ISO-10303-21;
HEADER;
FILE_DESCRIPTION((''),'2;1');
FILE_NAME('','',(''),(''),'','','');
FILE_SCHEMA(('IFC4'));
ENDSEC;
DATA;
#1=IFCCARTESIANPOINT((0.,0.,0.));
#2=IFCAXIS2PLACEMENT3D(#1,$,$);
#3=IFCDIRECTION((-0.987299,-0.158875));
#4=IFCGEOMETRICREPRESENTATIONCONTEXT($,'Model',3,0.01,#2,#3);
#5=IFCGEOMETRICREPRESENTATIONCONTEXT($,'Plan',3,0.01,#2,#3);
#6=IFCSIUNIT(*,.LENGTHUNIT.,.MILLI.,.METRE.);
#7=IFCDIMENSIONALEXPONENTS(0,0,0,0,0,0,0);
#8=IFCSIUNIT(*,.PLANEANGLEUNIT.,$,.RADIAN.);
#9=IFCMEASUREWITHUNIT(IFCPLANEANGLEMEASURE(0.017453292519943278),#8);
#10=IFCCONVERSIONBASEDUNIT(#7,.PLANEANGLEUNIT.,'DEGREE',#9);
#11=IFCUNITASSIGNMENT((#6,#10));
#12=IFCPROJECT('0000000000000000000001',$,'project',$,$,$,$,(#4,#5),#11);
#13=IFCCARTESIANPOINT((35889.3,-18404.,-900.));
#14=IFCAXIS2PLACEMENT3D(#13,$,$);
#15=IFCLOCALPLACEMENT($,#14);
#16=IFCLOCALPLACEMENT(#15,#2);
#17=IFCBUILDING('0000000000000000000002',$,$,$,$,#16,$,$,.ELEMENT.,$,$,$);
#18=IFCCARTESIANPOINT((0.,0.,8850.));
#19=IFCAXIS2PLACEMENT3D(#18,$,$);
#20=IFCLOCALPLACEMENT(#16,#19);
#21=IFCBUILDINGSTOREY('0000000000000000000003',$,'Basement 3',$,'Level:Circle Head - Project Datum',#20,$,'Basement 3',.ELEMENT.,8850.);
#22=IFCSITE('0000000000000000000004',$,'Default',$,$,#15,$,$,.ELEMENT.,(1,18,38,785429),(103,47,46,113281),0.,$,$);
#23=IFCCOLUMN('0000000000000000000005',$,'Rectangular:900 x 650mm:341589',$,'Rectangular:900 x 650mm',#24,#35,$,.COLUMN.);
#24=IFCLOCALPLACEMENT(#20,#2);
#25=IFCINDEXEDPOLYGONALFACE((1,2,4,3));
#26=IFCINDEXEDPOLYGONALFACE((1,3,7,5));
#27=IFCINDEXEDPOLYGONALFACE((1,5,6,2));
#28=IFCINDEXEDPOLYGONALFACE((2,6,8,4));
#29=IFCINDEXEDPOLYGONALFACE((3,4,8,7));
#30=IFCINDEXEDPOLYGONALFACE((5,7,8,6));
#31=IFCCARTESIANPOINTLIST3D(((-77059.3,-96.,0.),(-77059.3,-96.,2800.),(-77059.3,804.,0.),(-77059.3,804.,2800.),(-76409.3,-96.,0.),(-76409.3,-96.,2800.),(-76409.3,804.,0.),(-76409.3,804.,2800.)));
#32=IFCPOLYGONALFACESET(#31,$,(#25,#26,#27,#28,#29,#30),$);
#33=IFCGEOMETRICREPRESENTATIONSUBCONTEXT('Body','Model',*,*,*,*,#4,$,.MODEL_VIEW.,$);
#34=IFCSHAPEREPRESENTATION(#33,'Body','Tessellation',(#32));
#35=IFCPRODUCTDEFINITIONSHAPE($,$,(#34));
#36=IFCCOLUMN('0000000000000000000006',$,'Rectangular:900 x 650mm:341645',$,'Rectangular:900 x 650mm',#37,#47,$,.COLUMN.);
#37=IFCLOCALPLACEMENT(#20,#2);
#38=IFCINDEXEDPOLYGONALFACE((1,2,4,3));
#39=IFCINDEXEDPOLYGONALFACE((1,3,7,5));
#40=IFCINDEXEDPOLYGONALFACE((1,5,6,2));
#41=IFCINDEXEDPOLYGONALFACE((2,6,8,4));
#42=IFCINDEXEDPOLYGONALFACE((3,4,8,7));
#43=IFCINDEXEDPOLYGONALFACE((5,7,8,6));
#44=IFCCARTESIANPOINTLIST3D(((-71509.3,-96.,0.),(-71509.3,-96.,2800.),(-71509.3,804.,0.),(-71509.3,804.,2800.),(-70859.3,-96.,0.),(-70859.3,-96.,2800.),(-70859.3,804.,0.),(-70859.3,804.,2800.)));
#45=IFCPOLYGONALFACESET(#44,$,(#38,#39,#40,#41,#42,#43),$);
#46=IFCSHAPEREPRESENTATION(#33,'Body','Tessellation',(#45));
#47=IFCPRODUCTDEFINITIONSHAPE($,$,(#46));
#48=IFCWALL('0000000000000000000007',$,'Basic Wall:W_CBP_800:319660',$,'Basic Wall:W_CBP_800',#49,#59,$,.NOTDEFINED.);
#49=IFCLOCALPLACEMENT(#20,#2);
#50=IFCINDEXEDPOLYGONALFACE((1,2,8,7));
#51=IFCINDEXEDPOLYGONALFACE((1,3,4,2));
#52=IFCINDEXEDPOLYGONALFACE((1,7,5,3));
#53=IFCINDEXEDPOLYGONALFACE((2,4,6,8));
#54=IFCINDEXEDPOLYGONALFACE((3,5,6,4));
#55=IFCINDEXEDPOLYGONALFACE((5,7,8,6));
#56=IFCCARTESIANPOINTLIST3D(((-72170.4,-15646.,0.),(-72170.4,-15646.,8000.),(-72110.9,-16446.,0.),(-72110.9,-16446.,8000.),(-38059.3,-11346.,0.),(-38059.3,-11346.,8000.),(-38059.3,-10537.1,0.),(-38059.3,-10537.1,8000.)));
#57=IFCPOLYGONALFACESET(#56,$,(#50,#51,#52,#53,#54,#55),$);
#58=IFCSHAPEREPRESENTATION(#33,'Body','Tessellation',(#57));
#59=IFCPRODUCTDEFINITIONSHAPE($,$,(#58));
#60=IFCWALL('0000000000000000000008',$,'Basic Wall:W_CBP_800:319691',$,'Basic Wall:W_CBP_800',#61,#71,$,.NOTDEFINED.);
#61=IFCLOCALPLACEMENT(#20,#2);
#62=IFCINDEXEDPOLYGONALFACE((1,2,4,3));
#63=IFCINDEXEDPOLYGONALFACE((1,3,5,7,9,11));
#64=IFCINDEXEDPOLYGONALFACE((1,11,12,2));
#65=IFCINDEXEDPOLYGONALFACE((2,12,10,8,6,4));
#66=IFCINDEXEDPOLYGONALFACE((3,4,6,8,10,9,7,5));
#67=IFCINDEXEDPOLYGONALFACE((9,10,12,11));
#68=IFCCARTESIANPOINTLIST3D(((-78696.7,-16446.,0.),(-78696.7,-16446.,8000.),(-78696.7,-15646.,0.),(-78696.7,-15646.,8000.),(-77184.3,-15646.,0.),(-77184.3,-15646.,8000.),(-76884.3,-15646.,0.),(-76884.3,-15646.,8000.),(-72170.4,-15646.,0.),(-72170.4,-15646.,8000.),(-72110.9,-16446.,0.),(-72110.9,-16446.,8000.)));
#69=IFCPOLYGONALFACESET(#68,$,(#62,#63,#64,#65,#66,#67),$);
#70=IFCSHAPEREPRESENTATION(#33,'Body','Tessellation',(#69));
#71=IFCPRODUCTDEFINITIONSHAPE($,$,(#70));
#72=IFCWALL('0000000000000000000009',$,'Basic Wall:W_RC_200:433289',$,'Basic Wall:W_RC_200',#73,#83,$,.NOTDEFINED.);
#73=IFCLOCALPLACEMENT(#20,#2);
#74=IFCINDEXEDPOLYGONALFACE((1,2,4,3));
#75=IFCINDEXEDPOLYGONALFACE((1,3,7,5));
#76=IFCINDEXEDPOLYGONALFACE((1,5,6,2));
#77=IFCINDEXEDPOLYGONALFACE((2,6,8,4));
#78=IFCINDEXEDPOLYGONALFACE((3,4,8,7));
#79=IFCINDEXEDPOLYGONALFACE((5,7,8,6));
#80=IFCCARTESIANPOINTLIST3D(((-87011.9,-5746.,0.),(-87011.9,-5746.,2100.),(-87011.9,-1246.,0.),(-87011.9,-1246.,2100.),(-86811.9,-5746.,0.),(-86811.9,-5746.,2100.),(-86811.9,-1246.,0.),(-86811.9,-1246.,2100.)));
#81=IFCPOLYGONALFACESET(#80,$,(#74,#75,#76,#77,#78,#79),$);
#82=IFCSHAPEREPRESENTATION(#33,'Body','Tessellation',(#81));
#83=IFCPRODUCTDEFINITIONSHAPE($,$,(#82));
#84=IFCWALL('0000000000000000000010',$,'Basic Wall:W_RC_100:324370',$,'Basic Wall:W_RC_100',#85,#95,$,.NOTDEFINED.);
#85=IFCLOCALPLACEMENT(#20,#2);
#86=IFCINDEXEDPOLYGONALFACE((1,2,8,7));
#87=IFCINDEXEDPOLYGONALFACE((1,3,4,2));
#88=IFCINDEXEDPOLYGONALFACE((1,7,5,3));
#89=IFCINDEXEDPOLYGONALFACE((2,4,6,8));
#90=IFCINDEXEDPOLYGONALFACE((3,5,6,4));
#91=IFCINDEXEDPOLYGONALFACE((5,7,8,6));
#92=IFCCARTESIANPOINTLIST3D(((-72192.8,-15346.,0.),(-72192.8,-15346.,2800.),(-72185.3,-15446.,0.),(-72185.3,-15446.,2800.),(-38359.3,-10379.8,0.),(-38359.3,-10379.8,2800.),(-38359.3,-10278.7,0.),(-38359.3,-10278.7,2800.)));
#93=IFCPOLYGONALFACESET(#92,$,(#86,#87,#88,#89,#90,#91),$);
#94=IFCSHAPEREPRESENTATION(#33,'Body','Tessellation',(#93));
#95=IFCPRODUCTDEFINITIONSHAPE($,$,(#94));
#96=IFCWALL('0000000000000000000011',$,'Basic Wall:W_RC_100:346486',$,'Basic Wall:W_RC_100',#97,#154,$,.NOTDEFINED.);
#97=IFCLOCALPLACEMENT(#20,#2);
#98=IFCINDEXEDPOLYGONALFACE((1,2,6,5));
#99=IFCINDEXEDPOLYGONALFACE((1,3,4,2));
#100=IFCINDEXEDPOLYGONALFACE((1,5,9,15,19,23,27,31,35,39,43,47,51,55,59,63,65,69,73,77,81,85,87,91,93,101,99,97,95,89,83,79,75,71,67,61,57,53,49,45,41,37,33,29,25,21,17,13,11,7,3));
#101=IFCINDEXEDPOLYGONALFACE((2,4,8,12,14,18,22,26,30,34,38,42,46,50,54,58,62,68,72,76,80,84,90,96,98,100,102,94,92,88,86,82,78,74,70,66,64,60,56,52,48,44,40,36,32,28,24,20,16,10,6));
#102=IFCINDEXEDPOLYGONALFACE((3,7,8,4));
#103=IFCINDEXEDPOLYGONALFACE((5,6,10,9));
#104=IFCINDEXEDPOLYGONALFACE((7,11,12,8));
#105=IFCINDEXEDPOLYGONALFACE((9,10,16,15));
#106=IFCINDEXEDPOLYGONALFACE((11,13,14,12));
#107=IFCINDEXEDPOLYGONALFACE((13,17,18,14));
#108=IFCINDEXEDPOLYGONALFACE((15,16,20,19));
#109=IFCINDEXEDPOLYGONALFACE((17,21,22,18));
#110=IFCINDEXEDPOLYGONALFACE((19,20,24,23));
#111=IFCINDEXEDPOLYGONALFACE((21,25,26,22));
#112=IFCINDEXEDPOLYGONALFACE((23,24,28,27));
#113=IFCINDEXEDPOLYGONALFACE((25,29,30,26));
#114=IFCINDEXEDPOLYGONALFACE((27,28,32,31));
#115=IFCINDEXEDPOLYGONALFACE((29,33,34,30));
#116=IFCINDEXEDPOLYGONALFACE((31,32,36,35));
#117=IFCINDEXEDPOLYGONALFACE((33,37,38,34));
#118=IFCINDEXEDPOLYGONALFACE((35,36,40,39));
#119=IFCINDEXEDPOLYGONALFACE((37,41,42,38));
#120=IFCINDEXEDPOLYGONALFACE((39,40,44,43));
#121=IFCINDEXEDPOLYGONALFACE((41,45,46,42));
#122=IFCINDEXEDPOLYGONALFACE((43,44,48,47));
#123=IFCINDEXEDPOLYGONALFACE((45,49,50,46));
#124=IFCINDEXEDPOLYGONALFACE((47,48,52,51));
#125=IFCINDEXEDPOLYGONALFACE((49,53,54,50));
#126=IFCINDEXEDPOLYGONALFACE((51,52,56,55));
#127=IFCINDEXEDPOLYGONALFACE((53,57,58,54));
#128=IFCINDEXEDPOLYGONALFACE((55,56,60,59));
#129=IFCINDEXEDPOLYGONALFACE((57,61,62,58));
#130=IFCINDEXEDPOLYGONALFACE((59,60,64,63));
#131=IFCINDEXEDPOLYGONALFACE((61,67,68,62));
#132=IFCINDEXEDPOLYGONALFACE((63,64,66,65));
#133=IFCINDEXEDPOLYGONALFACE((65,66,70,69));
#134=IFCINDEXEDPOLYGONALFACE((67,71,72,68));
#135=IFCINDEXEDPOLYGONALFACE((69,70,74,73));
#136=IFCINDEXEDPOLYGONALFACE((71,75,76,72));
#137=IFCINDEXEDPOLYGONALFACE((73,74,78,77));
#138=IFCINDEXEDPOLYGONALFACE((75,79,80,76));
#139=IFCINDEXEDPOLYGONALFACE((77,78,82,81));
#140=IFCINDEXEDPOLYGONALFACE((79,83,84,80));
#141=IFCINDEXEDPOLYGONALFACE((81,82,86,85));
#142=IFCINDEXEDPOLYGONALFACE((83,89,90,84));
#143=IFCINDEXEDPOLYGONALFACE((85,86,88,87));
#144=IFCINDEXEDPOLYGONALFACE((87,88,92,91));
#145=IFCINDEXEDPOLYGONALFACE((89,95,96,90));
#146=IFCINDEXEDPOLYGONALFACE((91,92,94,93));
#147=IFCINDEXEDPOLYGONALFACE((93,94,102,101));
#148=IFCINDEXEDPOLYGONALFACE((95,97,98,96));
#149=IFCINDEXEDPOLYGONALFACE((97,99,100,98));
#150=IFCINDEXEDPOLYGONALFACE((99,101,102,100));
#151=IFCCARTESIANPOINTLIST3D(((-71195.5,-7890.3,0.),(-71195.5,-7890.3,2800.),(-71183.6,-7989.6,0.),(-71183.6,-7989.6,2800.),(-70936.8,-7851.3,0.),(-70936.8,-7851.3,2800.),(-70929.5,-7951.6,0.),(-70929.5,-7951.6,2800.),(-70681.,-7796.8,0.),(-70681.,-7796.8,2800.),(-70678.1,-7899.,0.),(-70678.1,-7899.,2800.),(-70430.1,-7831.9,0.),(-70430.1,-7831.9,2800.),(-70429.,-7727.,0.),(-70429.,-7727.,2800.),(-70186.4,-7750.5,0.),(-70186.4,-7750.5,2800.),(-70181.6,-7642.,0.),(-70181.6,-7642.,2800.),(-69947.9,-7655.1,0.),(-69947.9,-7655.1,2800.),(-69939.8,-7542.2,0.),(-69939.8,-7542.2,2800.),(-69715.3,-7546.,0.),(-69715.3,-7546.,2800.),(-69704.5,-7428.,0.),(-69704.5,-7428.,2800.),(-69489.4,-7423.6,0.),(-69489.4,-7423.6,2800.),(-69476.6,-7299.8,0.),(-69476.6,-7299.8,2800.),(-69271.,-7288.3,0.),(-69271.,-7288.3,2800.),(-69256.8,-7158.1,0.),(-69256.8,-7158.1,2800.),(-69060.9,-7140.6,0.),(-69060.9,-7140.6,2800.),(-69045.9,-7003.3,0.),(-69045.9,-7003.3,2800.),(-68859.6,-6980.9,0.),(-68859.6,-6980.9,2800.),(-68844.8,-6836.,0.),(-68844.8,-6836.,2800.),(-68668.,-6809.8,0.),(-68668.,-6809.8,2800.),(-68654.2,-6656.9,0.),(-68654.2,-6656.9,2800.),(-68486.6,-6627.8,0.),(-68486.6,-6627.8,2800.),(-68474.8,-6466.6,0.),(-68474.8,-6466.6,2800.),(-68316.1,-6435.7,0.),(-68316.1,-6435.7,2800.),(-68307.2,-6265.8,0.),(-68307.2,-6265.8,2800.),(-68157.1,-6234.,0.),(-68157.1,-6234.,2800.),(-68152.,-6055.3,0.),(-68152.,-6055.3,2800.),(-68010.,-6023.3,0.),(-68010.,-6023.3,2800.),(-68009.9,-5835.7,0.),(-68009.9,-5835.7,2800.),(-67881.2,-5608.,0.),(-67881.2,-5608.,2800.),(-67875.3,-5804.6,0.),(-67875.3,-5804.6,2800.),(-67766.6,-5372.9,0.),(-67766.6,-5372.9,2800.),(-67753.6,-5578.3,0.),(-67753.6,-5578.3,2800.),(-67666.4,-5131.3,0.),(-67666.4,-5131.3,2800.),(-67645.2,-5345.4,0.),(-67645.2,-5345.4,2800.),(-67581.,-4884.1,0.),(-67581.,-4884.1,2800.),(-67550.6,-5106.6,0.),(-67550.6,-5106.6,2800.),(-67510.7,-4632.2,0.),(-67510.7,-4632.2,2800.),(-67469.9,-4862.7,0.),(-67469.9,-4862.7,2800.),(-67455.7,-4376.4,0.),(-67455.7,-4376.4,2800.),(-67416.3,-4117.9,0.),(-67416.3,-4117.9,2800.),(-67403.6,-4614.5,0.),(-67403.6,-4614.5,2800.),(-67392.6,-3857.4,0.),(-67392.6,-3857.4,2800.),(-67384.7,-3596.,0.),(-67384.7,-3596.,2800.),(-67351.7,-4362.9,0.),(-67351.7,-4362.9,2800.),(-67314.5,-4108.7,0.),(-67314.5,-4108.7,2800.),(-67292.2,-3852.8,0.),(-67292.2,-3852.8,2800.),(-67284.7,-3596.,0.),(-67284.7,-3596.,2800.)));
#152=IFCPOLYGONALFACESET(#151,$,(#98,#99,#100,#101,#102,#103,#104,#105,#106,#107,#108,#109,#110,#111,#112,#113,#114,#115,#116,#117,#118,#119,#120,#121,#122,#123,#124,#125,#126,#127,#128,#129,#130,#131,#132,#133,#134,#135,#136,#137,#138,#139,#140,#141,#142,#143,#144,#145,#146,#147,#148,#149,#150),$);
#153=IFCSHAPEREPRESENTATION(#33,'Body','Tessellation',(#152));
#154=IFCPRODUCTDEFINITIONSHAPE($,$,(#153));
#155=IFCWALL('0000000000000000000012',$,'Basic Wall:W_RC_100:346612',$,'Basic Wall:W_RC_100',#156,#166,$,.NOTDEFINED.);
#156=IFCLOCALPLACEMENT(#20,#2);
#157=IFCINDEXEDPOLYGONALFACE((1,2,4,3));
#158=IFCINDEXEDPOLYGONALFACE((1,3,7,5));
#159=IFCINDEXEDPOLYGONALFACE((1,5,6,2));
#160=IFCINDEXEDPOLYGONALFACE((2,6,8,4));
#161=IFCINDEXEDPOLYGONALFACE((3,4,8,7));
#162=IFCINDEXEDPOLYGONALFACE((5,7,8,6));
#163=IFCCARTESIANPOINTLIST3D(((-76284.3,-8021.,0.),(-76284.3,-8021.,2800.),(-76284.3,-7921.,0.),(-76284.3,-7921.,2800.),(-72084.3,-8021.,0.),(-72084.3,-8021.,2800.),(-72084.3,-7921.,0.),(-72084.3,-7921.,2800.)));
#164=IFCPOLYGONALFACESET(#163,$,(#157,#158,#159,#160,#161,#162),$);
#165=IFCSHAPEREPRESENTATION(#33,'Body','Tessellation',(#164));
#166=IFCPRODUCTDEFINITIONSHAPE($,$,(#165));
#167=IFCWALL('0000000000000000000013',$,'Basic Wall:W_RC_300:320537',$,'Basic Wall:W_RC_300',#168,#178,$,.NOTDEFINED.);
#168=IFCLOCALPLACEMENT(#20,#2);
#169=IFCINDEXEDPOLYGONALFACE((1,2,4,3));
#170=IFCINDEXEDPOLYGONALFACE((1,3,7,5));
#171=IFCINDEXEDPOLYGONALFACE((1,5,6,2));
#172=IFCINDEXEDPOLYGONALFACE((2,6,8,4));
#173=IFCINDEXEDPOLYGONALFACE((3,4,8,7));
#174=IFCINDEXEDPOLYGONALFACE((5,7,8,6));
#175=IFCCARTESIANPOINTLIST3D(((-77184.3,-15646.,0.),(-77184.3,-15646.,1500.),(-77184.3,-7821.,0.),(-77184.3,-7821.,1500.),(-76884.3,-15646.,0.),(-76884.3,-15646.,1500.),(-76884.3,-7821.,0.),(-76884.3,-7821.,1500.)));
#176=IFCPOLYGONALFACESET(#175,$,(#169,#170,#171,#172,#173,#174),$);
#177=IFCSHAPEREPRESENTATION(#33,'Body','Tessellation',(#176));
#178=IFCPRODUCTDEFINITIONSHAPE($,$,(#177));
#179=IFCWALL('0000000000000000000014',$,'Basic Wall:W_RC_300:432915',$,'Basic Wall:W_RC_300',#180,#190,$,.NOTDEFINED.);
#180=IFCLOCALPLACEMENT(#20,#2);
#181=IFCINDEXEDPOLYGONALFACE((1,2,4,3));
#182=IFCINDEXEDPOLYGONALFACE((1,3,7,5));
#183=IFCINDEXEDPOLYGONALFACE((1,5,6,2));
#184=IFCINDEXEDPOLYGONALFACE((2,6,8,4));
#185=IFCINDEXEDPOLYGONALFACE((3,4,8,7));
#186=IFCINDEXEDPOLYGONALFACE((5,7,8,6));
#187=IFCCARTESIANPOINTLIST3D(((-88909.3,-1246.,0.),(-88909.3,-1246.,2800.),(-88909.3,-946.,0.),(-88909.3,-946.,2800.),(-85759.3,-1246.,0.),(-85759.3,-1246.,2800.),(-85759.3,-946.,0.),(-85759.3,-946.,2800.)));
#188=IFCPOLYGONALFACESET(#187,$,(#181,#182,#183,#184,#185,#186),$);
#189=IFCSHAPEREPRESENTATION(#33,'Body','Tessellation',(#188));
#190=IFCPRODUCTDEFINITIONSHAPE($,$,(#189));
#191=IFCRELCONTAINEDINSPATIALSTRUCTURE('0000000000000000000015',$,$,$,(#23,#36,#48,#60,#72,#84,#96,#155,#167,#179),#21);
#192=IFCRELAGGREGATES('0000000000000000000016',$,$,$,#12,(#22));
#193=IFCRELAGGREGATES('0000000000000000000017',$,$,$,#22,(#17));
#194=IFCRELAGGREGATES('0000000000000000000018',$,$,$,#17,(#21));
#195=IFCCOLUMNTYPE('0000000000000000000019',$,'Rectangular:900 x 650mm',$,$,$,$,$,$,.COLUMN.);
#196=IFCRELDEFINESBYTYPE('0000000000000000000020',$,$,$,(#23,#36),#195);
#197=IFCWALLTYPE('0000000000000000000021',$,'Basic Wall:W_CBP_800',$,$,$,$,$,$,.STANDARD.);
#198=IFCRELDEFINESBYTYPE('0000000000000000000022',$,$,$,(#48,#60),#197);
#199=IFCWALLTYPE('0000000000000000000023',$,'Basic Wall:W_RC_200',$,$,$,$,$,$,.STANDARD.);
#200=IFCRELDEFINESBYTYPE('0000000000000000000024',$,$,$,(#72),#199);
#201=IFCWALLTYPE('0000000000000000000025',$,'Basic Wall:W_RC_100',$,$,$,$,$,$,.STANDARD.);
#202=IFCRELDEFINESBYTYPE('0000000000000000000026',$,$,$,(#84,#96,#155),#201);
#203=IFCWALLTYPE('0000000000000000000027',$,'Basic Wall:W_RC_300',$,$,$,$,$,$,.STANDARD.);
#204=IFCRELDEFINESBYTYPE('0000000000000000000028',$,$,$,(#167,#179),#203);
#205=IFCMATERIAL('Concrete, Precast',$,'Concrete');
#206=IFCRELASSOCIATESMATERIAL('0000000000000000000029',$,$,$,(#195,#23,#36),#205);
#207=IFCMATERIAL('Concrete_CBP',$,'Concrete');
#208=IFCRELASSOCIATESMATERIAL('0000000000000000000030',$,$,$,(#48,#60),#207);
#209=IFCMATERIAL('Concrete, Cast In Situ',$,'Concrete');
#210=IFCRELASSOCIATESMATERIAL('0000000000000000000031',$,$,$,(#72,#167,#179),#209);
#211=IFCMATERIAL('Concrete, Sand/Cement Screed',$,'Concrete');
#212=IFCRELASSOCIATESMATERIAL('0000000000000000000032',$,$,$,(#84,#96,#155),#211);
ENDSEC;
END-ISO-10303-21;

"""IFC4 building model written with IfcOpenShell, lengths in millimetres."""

from ifc_helpers import new_model, entity, si_unit, converted_unit, direction, frame, origin, place, context, subcontext, project, spatial, line, arc, indexed_curve, outline, extrude, source, transform, mapped, material, type_object, type_shapes, element, save


model = new_model("IFC4")

# Units and contexts
model_context = context("Model", 3, precision=0.01, world=origin(), true_north=direction((-0.987299, -0.158875)))
plan_context = context("Plan", 3, precision=0.01, world=origin(), true_north=direction((-0.987299, -0.158875)))
body_context = subcontext(model_context, "Body", "Model", "MODEL_VIEW")
ifc_project = project(units=[si_unit("LENGTHUNIT", "METRE", prefix="MILLI"), converted_unit("PLANEANGLEUNIT", "DEGREE", entity("IfcPlaneAngleMeasure", 0.017453292519943278), si_unit("PLANEANGLEUNIT", "RADIAN"), dimensions=[0, 0, 0, 0, 0, 0, 0])], contexts=[model_context, plan_context])

# Site, building, storey
site_placement = place(None, frame((35889.3, -18404.0, -900.0)))
site = spatial("IfcSite", under=ifc_project, at=site_placement, Name="Default", CompositionType="ELEMENT", RefLatitude=(1, 18, 38, 785429), RefLongitude=(103, 47, 46, 113281), RefElevation=0.0)
building_placement = place(site_placement, origin())
building = spatial("IfcBuilding", under=site, at=building_placement, CompositionType="ELEMENT")
storey_placement = place(building_placement, frame((0.0, 0.0, 8850.0)))
storey = spatial("IfcBuildingStorey", under=building, at=storey_placement, Name="Basement 3", ObjectType="Level:Circle Head - Project Datum", LongName="Basement 3", CompositionType="ELEMENT", Elevation=8850.0)

# Columns
ifc_material_1 = material(Name="Concrete, Precast", Category="Concrete")
column_type = type_object("IfcColumnType", Name="Rectangular:900 x 650mm", PredefinedType="COLUMN", material=ifc_material_1)
shared_shape = source(origin(), body_context, "Body", "SweptSolid", [
    extrude(outline(indexed_curve([(-325.0, -450.0), (325.0, -450.0), (325.0, 450.0), (-325.0, 450.0), (-325.0, -450.0)], self_intersect=False)), frame((0.0, 0.0, 8850.0), z_axis=(0.0, 0.0, 1.0), x_axis=(-1.0, 0.0, 0.0)), (0.0, 0.0, 1.0), 2800.0),
])
type_shapes(column_type, [shared_shape])
for number, where, name in (
    (1, (-76734.3, 354.0, -8850.0), "Rectangular:900 x 650mm:341589"),
    (2, (-71184.3, 354.0, -8850.0), "Rectangular:900 x 650mm:341645"),
):
    element("IfcColumn", number, at=place(storey_placement, frame(where)), inside=storey, type_object=column_type, material=ifc_material_1, Name=name, ObjectType="Rectangular:900 x 650mm", PredefinedType="COLUMN", context=body_context, shape_type="MappedRepresentation", body=[
        mapped(shared_shape, transform((0.0, 0.0, 0.0), scale=1.0)),
    ])

# Walls
ifc_material_2 = material(Name="Concrete_CBP", Category="Concrete")
wall_type_1 = type_object("IfcWallType", Name="Basic Wall:W_CBP_800", PredefinedType="STANDARD")
wall_1_placement = place(storey_placement, frame((-72170.1, -16050.4, 0.0), z_axis=(0.0, 0.0, 1.0), x_axis=(0.988969, 0.148119, 0.0)))
element("IfcWall", 3, at=wall_1_placement, inside=storey, type_object=wall_type_1, material=ifc_material_2, Name="Basic Wall:W_CBP_800:319660", ObjectType="Basic Wall:W_CBP_800", PredefinedType="NOTDEFINED", context=body_context, shape_type="SweptSolid", body=[
    extrude(outline(indexed_curve([(34431.3, -400.0), (34551.1, 400.0), (59.6, 400.0), (0.0, -400.0), (34431.3, -400.0)], self_intersect=False)), origin(), (0.0, 0.0, 1.0), 8000.0),
])
wall_2_placement = place(storey_placement, frame((-72110.9, -16046.0, 0.0), z_axis=(0.0, 0.0, 1.0), x_axis=(-1.0, 0.0, 0.0)))
element("IfcWall", 4, at=wall_2_placement, inside=storey, type_object=wall_type_1, material=ifc_material_2, Name="Basic Wall:W_CBP_800:319691", ObjectType="Basic Wall:W_CBP_800", PredefinedType="NOTDEFINED", context=body_context, shape_type="SweptSolid", body=[
    extrude(outline(indexed_curve([(6585.8, -400.0), (6585.8, 400.0), (0.0, 400.0), (59.6, -400.0), (4773.5, -400.0), (5073.5, -400.0), (6585.8, -400.0)], self_intersect=False)), origin(), (0.0, 0.0, 1.0), 8000.0),
])
ifc_material_3 = material(Name="Concrete, Cast In Situ", Category="Concrete")
wall_type_2 = type_object("IfcWallType", Name="Basic Wall:W_RC_200", PredefinedType="STANDARD")
wall_3_placement = place(storey_placement, frame((-86911.9, -1246.0, 0.0), z_axis=(0.0, 0.0, 1.0), x_axis=(0.0, -1.0, 0.0)))
element("IfcWall", 5, at=wall_3_placement, inside=storey, type_object=wall_type_2, material=ifc_material_3, Name="Basic Wall:W_RC_200:433289", ObjectType="Basic Wall:W_RC_200", PredefinedType="NOTDEFINED", context=body_context, shape_type="SweptSolid", body=[
    extrude(outline(indexed_curve([(4500.0, 100.0), (0.0, 100.0), (0.0, -100.0), (4500.0, -100.0), (4500.0, 100.0)], self_intersect=False)), origin(), (0.0, 0.0, 1.0), 2100.0),
])
ifc_material_4 = material(Name="Concrete, Sand/Cement Screed", Category="Concrete")
wall_type_3 = type_object("IfcWallType", Name="Basic Wall:W_RC_100", PredefinedType="STANDARD")
wall_4_placement = place(storey_placement, frame((-72192.7, -15396.5, 0.0), z_axis=(0.0, 0.0, 1.0), x_axis=(0.988969, 0.148119, 0.0)))
element("IfcWall", 6, at=wall_4_placement, inside=storey, type_object=wall_type_3, material=ifc_material_4, Name="Basic Wall:W_RC_100:324370", ObjectType="Basic Wall:W_RC_100", PredefinedType="NOTDEFINED", context=body_context, shape_type="SweptSolid", body=[
    extrude(outline(indexed_curve([(34203.3, -50.0), (34218.2, 50.0), (7.4, 50.0), (0.0, -50.0), (34203.3, -50.0)], self_intersect=False)), origin(), (0.0, 0.0, 1.0), 2800.0),
])
wall_5_placement = place(storey_placement, frame((-71189.5, -7939.9, 0.0)))
element("IfcWall", 7, at=wall_5_placement, inside=storey, type_object=wall_type_3, material=ifc_material_4, Name="Basic Wall:W_RC_100:346486", ObjectType="Basic Wall:W_RC_100", PredefinedType="NOTDEFINED", context=body_context, shape_type="SweptSolid", body=[
    extrude(outline(indexed_curve([(3804.8, 4344.0), (2714.7, 1473.3), (-5.9, 49.6), (5.9, -49.6), (2789.5, 1406.9), (3904.8, 4344.0)], segments=[arc(1, 2, 3), line(3, 4), arc(4, 5, 6), line(6, 1)], self_intersect=False)), origin(), (0.0, 0.0, 1.0), 2800.0),
])
wall_6_placement = place(storey_placement, frame((-76284.3, -7971.0, 0.0)))
element("IfcWall", 8, at=wall_6_placement, inside=storey, type_object=wall_type_3, material=ifc_material_4, Name="Basic Wall:W_RC_100:346612", ObjectType="Basic Wall:W_RC_100", PredefinedType="NOTDEFINED", context=body_context, shape_type="SweptSolid", body=[
    extrude(outline(indexed_curve([(4200.0, 50.0), (0.0, 50.0), (0.0, -50.0), (4200.0, -50.0), (4200.0, 50.0)], self_intersect=False)), origin(), (0.0, 0.0, 1.0), 2800.0),
])
wall_type_4 = type_object("IfcWallType", Name="Basic Wall:W_RC_300", PredefinedType="STANDARD")
wall_7_placement = place(storey_placement, frame((-77034.3, -15646.0, 0.0), z_axis=(0.0, 0.0, 1.0), x_axis=(0.0, 1.0, 0.0)))
element("IfcWall", 9, at=wall_7_placement, inside=storey, type_object=wall_type_4, material=ifc_material_3, Name="Basic Wall:W_RC_300:320537", ObjectType="Basic Wall:W_RC_300", PredefinedType="NOTDEFINED", context=body_context, shape_type="SweptSolid", body=[
    extrude(outline(indexed_curve([(7825.0, 150.0), (0.0, 150.0), (0.0, -150.0), (7825.0, -150.0), (7825.0, 150.0)], self_intersect=False)), origin(), (0.0, 0.0, 1.0), 1500.0),
])
wall_8_placement = place(storey_placement, frame((-88909.3, -1096.0, 0.0)))
element("IfcWall", 10, at=wall_8_placement, inside=storey, type_object=wall_type_4, material=ifc_material_3, Name="Basic Wall:W_RC_300:432915", ObjectType="Basic Wall:W_RC_300", PredefinedType="NOTDEFINED", context=body_context, shape_type="SweptSolid", body=[
    extrude(outline(indexed_curve([(3150.0, 150.0), (0.0, 150.0), (0.0, -150.0), (3150.0, -150.0), (3150.0, 150.0)], self_intersect=False)), origin(), (0.0, 0.0, 1.0), 2800.0),
])

save(model, "model.ifc")
